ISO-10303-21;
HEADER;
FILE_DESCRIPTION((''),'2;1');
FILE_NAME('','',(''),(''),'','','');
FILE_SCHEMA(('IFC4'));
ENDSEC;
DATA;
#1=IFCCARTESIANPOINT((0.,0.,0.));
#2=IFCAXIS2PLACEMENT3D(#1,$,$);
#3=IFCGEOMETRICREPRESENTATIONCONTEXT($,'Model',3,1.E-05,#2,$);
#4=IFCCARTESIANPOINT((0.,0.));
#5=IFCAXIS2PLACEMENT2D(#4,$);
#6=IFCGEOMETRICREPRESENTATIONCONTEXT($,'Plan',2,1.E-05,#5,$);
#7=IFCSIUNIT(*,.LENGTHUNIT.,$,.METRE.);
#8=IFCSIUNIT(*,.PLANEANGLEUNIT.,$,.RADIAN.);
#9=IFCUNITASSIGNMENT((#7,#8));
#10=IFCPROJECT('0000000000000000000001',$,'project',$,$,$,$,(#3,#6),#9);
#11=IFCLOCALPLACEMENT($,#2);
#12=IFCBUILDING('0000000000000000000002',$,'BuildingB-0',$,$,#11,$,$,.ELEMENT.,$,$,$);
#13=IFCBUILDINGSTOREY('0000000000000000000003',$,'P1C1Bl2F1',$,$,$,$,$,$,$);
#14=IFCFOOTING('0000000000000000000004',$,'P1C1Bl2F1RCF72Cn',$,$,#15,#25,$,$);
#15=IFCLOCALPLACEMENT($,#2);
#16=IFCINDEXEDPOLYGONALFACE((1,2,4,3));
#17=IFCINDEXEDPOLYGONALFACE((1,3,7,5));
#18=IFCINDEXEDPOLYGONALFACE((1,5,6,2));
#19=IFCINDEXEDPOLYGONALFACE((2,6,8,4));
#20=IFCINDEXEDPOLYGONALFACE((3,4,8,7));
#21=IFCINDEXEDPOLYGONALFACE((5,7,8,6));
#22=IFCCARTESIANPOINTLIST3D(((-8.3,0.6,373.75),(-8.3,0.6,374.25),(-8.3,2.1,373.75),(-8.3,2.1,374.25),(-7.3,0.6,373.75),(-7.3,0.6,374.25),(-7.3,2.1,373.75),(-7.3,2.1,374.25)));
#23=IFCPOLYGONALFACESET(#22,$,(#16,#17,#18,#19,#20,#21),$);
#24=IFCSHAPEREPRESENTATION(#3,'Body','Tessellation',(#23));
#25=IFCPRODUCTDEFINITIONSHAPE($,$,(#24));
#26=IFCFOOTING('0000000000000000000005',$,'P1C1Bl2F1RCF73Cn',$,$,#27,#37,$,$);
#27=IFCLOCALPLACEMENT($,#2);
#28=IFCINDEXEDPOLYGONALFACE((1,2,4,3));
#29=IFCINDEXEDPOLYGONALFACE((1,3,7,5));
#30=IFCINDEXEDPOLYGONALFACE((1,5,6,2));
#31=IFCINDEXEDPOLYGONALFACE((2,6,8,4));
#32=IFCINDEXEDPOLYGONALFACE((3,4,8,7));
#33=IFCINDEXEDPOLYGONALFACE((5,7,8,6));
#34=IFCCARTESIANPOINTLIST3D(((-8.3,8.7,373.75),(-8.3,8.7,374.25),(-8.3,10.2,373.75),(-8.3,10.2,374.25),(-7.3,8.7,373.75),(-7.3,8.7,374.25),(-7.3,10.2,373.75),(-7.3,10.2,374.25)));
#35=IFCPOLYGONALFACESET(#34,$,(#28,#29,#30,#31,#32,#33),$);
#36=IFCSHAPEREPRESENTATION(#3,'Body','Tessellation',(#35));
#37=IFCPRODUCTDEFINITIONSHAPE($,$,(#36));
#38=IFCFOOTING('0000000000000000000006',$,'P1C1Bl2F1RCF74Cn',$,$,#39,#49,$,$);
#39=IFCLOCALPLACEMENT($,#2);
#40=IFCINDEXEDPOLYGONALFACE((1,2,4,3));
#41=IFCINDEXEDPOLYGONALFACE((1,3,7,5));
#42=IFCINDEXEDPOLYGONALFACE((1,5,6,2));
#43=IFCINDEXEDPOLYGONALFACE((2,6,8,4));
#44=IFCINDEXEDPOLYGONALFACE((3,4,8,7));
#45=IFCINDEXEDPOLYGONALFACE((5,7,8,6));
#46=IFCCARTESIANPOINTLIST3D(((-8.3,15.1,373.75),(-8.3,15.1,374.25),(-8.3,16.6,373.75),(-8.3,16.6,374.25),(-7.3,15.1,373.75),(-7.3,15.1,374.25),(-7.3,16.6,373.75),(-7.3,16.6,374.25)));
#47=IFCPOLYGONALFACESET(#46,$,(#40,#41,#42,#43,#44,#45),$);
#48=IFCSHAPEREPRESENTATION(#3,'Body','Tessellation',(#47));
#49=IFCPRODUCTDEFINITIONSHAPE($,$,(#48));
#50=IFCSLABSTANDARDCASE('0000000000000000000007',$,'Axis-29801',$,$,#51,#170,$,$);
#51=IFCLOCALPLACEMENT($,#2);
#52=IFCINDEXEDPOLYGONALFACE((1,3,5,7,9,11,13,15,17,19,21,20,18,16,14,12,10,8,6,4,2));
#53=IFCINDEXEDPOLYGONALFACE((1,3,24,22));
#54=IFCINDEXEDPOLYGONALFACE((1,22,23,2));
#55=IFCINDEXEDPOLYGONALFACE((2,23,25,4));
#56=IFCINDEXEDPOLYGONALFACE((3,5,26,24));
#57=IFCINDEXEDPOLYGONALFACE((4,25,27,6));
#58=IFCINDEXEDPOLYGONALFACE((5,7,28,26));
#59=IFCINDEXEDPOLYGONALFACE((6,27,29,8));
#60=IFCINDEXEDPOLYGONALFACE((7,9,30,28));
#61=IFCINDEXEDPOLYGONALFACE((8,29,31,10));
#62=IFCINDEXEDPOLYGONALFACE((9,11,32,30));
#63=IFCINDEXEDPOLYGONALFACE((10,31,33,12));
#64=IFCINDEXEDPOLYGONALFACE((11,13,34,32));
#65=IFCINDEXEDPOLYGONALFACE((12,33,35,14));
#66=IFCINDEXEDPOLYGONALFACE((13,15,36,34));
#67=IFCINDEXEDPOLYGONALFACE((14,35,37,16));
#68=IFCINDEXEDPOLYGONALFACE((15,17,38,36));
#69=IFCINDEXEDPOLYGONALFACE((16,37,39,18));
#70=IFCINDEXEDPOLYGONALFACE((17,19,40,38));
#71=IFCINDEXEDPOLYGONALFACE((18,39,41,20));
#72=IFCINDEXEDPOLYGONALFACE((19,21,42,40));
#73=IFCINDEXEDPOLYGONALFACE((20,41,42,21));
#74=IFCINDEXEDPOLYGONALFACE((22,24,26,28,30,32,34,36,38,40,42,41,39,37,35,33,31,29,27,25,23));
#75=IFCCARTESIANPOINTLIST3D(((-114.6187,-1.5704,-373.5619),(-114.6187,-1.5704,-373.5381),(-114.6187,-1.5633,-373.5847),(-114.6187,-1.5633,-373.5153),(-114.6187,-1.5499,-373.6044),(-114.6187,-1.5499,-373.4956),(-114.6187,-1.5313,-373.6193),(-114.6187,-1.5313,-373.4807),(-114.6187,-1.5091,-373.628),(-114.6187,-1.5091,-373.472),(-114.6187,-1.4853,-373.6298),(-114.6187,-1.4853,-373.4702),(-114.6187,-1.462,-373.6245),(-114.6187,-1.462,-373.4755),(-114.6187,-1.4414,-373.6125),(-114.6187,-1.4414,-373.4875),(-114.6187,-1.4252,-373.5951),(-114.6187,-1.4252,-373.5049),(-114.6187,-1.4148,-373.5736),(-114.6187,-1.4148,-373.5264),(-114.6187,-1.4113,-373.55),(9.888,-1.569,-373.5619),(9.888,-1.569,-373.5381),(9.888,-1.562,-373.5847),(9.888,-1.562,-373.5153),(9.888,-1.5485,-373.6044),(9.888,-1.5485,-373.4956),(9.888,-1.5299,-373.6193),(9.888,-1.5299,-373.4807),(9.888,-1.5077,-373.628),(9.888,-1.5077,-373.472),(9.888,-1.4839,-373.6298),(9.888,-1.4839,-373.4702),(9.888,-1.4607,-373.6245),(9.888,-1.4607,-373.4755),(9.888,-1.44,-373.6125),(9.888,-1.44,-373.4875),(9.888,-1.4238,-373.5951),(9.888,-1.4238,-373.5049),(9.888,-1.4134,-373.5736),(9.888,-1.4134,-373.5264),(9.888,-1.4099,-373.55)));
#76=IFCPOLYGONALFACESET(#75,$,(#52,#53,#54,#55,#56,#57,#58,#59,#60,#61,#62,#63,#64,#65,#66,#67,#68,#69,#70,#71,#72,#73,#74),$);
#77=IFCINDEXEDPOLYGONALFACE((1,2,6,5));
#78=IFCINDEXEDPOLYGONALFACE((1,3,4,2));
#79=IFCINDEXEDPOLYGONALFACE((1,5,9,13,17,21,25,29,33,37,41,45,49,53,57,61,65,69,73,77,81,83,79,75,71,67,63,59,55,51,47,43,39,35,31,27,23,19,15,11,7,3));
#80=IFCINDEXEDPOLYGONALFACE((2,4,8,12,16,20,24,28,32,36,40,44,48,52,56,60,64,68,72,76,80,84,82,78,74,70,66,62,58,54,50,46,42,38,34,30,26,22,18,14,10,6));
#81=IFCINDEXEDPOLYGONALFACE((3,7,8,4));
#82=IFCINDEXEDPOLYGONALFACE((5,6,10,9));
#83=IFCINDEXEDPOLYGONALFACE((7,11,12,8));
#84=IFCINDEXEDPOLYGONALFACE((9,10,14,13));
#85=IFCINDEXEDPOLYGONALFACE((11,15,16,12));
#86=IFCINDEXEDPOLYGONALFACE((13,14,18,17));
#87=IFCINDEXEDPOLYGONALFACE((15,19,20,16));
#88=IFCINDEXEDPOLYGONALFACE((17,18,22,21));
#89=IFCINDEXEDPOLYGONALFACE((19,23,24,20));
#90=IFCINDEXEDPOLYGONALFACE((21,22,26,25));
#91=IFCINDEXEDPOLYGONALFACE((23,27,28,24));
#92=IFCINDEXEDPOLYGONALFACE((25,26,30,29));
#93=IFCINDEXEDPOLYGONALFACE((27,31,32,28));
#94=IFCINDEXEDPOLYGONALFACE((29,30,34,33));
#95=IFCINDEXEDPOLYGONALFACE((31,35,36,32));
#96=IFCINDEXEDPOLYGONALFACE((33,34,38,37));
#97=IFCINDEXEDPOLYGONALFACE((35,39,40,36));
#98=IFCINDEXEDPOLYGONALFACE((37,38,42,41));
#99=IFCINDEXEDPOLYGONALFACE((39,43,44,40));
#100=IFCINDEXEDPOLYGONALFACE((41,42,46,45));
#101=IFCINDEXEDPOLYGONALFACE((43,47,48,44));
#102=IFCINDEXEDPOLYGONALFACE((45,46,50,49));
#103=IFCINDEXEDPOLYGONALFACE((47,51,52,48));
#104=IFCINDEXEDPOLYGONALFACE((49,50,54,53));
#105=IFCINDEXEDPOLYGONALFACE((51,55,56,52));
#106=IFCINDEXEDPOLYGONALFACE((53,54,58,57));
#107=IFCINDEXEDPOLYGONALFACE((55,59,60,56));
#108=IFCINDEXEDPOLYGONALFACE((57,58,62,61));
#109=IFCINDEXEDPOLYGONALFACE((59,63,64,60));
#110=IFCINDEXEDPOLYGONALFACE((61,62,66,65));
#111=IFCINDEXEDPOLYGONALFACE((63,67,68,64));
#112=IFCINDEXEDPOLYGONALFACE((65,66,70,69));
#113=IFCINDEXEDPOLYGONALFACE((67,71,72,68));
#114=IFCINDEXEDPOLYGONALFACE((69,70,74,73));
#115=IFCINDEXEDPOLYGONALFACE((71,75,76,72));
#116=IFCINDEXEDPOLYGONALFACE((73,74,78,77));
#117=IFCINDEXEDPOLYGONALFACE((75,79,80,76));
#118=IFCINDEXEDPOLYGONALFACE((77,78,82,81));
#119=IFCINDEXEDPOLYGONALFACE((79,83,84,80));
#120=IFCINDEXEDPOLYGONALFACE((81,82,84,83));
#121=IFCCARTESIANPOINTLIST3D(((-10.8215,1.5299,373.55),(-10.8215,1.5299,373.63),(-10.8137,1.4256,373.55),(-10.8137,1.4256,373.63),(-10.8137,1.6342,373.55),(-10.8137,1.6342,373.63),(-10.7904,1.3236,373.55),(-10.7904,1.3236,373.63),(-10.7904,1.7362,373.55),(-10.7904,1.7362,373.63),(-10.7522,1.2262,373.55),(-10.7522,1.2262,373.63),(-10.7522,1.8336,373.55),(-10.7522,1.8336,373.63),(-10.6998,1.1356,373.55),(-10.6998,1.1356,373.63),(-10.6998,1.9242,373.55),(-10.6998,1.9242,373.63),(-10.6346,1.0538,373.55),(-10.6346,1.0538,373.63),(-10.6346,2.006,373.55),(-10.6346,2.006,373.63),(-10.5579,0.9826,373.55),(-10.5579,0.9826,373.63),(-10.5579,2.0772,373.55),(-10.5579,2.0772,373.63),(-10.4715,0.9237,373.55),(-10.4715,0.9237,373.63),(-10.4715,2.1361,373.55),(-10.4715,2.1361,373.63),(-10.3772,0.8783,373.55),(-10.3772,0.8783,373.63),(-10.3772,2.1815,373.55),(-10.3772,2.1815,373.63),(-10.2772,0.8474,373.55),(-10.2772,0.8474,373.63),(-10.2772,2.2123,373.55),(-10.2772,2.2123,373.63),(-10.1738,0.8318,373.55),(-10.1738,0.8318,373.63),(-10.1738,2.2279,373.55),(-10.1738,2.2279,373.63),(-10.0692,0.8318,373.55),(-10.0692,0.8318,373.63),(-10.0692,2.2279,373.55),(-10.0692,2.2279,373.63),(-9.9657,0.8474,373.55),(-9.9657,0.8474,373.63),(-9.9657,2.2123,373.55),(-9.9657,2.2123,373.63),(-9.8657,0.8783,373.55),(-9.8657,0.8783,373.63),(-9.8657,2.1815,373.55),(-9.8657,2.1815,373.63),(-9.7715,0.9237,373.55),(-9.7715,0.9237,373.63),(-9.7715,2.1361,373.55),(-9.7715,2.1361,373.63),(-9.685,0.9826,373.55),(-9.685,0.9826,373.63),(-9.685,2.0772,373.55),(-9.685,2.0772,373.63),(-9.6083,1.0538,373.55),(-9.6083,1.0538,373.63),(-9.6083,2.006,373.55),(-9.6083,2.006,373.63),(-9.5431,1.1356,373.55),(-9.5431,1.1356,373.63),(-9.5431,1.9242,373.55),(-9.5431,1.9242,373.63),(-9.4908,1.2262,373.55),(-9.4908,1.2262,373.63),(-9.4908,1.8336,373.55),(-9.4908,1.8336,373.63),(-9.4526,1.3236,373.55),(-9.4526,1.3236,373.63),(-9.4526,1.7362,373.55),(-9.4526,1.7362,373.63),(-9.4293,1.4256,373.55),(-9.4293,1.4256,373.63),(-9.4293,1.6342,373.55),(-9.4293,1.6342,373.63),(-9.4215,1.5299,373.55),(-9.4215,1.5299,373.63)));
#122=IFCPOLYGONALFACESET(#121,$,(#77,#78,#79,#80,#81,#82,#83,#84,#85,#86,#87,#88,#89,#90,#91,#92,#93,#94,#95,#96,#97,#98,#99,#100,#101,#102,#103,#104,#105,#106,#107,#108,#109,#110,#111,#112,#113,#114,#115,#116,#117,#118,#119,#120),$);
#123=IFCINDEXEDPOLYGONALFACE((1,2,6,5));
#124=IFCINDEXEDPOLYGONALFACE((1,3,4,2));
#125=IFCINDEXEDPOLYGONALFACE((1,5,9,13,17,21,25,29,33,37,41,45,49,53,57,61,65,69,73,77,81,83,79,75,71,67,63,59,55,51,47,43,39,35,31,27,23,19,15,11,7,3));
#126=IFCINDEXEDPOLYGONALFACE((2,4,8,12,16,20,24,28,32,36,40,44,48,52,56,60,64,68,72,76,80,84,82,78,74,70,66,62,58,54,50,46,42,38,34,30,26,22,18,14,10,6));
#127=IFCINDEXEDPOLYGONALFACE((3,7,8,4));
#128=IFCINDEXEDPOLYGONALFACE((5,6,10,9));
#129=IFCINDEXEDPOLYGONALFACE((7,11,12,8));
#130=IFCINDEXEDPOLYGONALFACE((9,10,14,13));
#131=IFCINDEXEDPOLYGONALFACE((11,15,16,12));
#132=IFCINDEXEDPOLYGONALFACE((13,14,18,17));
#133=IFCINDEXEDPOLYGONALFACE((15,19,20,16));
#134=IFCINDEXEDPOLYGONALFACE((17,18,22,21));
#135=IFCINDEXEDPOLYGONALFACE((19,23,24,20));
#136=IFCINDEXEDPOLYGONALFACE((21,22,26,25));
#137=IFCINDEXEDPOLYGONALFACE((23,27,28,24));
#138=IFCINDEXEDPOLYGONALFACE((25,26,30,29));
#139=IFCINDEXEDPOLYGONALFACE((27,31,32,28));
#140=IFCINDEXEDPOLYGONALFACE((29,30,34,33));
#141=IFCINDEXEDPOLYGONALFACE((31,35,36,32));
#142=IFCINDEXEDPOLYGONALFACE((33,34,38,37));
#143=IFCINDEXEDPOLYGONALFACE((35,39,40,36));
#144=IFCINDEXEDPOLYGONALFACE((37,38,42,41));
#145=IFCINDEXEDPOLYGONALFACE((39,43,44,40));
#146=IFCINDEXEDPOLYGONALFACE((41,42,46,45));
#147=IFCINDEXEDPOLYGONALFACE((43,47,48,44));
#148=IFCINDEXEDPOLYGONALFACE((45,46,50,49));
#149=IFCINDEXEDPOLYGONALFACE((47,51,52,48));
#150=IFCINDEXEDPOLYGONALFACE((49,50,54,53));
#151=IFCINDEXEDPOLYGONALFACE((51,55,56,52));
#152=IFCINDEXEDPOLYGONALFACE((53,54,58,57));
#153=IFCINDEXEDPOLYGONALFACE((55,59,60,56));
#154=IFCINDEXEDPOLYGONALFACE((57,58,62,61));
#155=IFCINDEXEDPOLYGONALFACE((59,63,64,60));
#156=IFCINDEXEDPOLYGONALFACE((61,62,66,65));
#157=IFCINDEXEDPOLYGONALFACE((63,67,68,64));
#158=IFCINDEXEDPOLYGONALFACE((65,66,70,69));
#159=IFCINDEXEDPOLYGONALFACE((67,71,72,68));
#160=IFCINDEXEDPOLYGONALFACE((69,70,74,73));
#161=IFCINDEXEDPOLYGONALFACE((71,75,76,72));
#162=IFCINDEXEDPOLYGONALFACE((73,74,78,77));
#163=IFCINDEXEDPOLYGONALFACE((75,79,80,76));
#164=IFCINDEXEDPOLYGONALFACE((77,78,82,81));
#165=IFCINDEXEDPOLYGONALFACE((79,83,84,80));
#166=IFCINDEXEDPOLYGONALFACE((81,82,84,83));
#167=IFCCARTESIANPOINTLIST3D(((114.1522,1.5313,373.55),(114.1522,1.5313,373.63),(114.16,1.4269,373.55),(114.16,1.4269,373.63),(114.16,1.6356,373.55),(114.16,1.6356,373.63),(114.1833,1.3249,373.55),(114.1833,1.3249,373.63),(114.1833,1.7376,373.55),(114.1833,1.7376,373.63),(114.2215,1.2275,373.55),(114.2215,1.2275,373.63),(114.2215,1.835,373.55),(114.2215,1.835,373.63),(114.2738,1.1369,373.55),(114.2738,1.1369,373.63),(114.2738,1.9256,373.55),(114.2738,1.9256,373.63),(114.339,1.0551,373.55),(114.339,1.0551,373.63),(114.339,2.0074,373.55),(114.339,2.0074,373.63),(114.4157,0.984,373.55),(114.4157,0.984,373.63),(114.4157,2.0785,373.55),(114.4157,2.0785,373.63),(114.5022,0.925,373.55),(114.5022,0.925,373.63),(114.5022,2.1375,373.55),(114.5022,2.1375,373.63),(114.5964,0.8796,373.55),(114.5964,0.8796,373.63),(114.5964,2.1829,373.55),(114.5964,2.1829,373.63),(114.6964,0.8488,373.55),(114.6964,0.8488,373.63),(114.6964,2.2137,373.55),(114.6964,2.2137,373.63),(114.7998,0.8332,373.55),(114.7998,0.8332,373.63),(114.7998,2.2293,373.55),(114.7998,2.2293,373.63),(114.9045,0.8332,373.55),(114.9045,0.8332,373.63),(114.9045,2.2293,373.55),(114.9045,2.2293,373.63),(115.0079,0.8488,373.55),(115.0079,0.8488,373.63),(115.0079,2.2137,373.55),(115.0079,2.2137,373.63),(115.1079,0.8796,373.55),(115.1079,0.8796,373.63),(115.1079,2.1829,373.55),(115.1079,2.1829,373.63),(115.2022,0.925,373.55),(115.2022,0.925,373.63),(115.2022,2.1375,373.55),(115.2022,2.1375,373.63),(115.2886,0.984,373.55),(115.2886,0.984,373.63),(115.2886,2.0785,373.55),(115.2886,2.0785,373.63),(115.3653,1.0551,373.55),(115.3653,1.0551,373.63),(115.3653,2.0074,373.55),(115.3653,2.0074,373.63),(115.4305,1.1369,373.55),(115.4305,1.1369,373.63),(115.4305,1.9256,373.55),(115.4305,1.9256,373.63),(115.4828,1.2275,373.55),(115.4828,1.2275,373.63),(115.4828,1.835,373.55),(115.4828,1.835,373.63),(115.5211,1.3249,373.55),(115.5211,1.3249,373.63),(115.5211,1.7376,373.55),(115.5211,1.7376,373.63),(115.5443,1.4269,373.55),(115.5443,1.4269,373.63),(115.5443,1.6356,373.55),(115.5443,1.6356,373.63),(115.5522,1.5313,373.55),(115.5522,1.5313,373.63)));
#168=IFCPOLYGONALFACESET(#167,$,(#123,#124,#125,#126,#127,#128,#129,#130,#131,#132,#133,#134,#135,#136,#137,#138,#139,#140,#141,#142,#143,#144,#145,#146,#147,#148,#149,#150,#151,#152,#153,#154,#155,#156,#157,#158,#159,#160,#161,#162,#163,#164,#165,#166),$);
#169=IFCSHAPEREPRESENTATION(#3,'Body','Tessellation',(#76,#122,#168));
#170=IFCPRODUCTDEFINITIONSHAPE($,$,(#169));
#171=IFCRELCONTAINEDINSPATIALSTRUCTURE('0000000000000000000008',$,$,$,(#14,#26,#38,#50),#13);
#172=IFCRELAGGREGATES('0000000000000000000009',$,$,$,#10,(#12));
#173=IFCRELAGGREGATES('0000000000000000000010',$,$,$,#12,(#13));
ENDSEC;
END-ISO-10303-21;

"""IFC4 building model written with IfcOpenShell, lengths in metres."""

from ifc_helpers import new_model, entity, si_unit, frame, origin, origin_2d, place, context, project, spatial, polyline, circle, outline, extrude, element, save


model = new_model("IFC4")

# Units and contexts
model_context = context("Model", 3, precision=1e-05, world=origin())
plan_context = context("Plan", 2, precision=1e-05, world=origin_2d())
ifc_project = project(units=[si_unit("LENGTHUNIT", "METRE"), si_unit("PLANEANGLEUNIT", "RADIAN")], contexts=[model_context, plan_context])

# Building, storey
building_placement = place(None, origin())
building = spatial("IfcBuilding", under=ifc_project, at=building_placement, Name="BuildingB-0", CompositionType="ELEMENT")
storey = spatial("IfcBuildingStorey", under=building, Name="P1C1Bl2F1")

# Footings
element("IfcFooting", 1, inside=storey, Name="P1C1Bl2F1RCF72Cn", context=model_context, shape_type="SweptSolid", body=[
    extrude(outline(polyline([(-7.3, 2.1, 373.75), (-8.3, 2.1, 373.75), (-8.3, 0.6, 373.75), (-7.3, 0.6, 373.75), (-7.3, 2.1, 373.75)])), None, (0.0, 0.0, 1.0), 0.5),
])
element("IfcFooting", 2, inside=storey, Name="P1C1Bl2F1RCF73Cn", context=model_context, shape_type="SweptSolid", body=[
    extrude(outline(polyline([(-7.3, 10.2, 373.75), (-8.3, 10.2, 373.75), (-8.3, 8.7, 373.75), (-7.3, 8.7, 373.75), (-7.3, 10.2, 373.75)])), None, (0.0, 0.0, 1.0), 0.5),
])
element("IfcFooting", 3, inside=storey, Name="P1C1Bl2F1RCF74Cn", context=model_context, shape_type="SweptSolid", body=[
    extrude(outline(polyline([(-7.3, 16.6, 373.75), (-8.3, 16.6, 373.75), (-8.3, 15.1, 373.75), (-7.3, 15.1, 373.75), (-7.3, 16.6, 373.75)])), None, (0.0, 0.0, 1.0), 0.5),
])

# Slab
element("IfcSlabStandardCase", 4, inside=storey, Name="Axis-29801", context=model_context, shape_type="AdvancedSweptSolid", body=[
    entity("IfcSurfaceCurveSweptAreaSolid", entity("IfcCircleProfileDef", "AREA", None, None, 0.08), None, entity("IfcPolyline", [entity("IfcCartesianPoint", [-9.888, 1.4899, 373.55]), entity("IfcCartesianPoint", [114.6187, 1.4913, 373.55])]), None, None, entity("IfcPlane", entity("IfcAxis2Placement3D", entity("IfcCartesianPoint", [-9.888, 1.4899, 373.55]), entity("IfcDirection", [0.0, 0.0, 1.0]), entity("IfcDirection", [1.0, 0.0, 0.0])))),
    extrude(circle(Radius=0.7), frame((-10.1215, 1.5299, 373.55)), (0.0, 0.0, 1.0), 0.08),
    extrude(circle(Radius=0.7), frame((114.8522, 1.5313, 373.55)), (0.0, 0.0, 1.0), 0.08),
])

save(model, "model.ifc")
